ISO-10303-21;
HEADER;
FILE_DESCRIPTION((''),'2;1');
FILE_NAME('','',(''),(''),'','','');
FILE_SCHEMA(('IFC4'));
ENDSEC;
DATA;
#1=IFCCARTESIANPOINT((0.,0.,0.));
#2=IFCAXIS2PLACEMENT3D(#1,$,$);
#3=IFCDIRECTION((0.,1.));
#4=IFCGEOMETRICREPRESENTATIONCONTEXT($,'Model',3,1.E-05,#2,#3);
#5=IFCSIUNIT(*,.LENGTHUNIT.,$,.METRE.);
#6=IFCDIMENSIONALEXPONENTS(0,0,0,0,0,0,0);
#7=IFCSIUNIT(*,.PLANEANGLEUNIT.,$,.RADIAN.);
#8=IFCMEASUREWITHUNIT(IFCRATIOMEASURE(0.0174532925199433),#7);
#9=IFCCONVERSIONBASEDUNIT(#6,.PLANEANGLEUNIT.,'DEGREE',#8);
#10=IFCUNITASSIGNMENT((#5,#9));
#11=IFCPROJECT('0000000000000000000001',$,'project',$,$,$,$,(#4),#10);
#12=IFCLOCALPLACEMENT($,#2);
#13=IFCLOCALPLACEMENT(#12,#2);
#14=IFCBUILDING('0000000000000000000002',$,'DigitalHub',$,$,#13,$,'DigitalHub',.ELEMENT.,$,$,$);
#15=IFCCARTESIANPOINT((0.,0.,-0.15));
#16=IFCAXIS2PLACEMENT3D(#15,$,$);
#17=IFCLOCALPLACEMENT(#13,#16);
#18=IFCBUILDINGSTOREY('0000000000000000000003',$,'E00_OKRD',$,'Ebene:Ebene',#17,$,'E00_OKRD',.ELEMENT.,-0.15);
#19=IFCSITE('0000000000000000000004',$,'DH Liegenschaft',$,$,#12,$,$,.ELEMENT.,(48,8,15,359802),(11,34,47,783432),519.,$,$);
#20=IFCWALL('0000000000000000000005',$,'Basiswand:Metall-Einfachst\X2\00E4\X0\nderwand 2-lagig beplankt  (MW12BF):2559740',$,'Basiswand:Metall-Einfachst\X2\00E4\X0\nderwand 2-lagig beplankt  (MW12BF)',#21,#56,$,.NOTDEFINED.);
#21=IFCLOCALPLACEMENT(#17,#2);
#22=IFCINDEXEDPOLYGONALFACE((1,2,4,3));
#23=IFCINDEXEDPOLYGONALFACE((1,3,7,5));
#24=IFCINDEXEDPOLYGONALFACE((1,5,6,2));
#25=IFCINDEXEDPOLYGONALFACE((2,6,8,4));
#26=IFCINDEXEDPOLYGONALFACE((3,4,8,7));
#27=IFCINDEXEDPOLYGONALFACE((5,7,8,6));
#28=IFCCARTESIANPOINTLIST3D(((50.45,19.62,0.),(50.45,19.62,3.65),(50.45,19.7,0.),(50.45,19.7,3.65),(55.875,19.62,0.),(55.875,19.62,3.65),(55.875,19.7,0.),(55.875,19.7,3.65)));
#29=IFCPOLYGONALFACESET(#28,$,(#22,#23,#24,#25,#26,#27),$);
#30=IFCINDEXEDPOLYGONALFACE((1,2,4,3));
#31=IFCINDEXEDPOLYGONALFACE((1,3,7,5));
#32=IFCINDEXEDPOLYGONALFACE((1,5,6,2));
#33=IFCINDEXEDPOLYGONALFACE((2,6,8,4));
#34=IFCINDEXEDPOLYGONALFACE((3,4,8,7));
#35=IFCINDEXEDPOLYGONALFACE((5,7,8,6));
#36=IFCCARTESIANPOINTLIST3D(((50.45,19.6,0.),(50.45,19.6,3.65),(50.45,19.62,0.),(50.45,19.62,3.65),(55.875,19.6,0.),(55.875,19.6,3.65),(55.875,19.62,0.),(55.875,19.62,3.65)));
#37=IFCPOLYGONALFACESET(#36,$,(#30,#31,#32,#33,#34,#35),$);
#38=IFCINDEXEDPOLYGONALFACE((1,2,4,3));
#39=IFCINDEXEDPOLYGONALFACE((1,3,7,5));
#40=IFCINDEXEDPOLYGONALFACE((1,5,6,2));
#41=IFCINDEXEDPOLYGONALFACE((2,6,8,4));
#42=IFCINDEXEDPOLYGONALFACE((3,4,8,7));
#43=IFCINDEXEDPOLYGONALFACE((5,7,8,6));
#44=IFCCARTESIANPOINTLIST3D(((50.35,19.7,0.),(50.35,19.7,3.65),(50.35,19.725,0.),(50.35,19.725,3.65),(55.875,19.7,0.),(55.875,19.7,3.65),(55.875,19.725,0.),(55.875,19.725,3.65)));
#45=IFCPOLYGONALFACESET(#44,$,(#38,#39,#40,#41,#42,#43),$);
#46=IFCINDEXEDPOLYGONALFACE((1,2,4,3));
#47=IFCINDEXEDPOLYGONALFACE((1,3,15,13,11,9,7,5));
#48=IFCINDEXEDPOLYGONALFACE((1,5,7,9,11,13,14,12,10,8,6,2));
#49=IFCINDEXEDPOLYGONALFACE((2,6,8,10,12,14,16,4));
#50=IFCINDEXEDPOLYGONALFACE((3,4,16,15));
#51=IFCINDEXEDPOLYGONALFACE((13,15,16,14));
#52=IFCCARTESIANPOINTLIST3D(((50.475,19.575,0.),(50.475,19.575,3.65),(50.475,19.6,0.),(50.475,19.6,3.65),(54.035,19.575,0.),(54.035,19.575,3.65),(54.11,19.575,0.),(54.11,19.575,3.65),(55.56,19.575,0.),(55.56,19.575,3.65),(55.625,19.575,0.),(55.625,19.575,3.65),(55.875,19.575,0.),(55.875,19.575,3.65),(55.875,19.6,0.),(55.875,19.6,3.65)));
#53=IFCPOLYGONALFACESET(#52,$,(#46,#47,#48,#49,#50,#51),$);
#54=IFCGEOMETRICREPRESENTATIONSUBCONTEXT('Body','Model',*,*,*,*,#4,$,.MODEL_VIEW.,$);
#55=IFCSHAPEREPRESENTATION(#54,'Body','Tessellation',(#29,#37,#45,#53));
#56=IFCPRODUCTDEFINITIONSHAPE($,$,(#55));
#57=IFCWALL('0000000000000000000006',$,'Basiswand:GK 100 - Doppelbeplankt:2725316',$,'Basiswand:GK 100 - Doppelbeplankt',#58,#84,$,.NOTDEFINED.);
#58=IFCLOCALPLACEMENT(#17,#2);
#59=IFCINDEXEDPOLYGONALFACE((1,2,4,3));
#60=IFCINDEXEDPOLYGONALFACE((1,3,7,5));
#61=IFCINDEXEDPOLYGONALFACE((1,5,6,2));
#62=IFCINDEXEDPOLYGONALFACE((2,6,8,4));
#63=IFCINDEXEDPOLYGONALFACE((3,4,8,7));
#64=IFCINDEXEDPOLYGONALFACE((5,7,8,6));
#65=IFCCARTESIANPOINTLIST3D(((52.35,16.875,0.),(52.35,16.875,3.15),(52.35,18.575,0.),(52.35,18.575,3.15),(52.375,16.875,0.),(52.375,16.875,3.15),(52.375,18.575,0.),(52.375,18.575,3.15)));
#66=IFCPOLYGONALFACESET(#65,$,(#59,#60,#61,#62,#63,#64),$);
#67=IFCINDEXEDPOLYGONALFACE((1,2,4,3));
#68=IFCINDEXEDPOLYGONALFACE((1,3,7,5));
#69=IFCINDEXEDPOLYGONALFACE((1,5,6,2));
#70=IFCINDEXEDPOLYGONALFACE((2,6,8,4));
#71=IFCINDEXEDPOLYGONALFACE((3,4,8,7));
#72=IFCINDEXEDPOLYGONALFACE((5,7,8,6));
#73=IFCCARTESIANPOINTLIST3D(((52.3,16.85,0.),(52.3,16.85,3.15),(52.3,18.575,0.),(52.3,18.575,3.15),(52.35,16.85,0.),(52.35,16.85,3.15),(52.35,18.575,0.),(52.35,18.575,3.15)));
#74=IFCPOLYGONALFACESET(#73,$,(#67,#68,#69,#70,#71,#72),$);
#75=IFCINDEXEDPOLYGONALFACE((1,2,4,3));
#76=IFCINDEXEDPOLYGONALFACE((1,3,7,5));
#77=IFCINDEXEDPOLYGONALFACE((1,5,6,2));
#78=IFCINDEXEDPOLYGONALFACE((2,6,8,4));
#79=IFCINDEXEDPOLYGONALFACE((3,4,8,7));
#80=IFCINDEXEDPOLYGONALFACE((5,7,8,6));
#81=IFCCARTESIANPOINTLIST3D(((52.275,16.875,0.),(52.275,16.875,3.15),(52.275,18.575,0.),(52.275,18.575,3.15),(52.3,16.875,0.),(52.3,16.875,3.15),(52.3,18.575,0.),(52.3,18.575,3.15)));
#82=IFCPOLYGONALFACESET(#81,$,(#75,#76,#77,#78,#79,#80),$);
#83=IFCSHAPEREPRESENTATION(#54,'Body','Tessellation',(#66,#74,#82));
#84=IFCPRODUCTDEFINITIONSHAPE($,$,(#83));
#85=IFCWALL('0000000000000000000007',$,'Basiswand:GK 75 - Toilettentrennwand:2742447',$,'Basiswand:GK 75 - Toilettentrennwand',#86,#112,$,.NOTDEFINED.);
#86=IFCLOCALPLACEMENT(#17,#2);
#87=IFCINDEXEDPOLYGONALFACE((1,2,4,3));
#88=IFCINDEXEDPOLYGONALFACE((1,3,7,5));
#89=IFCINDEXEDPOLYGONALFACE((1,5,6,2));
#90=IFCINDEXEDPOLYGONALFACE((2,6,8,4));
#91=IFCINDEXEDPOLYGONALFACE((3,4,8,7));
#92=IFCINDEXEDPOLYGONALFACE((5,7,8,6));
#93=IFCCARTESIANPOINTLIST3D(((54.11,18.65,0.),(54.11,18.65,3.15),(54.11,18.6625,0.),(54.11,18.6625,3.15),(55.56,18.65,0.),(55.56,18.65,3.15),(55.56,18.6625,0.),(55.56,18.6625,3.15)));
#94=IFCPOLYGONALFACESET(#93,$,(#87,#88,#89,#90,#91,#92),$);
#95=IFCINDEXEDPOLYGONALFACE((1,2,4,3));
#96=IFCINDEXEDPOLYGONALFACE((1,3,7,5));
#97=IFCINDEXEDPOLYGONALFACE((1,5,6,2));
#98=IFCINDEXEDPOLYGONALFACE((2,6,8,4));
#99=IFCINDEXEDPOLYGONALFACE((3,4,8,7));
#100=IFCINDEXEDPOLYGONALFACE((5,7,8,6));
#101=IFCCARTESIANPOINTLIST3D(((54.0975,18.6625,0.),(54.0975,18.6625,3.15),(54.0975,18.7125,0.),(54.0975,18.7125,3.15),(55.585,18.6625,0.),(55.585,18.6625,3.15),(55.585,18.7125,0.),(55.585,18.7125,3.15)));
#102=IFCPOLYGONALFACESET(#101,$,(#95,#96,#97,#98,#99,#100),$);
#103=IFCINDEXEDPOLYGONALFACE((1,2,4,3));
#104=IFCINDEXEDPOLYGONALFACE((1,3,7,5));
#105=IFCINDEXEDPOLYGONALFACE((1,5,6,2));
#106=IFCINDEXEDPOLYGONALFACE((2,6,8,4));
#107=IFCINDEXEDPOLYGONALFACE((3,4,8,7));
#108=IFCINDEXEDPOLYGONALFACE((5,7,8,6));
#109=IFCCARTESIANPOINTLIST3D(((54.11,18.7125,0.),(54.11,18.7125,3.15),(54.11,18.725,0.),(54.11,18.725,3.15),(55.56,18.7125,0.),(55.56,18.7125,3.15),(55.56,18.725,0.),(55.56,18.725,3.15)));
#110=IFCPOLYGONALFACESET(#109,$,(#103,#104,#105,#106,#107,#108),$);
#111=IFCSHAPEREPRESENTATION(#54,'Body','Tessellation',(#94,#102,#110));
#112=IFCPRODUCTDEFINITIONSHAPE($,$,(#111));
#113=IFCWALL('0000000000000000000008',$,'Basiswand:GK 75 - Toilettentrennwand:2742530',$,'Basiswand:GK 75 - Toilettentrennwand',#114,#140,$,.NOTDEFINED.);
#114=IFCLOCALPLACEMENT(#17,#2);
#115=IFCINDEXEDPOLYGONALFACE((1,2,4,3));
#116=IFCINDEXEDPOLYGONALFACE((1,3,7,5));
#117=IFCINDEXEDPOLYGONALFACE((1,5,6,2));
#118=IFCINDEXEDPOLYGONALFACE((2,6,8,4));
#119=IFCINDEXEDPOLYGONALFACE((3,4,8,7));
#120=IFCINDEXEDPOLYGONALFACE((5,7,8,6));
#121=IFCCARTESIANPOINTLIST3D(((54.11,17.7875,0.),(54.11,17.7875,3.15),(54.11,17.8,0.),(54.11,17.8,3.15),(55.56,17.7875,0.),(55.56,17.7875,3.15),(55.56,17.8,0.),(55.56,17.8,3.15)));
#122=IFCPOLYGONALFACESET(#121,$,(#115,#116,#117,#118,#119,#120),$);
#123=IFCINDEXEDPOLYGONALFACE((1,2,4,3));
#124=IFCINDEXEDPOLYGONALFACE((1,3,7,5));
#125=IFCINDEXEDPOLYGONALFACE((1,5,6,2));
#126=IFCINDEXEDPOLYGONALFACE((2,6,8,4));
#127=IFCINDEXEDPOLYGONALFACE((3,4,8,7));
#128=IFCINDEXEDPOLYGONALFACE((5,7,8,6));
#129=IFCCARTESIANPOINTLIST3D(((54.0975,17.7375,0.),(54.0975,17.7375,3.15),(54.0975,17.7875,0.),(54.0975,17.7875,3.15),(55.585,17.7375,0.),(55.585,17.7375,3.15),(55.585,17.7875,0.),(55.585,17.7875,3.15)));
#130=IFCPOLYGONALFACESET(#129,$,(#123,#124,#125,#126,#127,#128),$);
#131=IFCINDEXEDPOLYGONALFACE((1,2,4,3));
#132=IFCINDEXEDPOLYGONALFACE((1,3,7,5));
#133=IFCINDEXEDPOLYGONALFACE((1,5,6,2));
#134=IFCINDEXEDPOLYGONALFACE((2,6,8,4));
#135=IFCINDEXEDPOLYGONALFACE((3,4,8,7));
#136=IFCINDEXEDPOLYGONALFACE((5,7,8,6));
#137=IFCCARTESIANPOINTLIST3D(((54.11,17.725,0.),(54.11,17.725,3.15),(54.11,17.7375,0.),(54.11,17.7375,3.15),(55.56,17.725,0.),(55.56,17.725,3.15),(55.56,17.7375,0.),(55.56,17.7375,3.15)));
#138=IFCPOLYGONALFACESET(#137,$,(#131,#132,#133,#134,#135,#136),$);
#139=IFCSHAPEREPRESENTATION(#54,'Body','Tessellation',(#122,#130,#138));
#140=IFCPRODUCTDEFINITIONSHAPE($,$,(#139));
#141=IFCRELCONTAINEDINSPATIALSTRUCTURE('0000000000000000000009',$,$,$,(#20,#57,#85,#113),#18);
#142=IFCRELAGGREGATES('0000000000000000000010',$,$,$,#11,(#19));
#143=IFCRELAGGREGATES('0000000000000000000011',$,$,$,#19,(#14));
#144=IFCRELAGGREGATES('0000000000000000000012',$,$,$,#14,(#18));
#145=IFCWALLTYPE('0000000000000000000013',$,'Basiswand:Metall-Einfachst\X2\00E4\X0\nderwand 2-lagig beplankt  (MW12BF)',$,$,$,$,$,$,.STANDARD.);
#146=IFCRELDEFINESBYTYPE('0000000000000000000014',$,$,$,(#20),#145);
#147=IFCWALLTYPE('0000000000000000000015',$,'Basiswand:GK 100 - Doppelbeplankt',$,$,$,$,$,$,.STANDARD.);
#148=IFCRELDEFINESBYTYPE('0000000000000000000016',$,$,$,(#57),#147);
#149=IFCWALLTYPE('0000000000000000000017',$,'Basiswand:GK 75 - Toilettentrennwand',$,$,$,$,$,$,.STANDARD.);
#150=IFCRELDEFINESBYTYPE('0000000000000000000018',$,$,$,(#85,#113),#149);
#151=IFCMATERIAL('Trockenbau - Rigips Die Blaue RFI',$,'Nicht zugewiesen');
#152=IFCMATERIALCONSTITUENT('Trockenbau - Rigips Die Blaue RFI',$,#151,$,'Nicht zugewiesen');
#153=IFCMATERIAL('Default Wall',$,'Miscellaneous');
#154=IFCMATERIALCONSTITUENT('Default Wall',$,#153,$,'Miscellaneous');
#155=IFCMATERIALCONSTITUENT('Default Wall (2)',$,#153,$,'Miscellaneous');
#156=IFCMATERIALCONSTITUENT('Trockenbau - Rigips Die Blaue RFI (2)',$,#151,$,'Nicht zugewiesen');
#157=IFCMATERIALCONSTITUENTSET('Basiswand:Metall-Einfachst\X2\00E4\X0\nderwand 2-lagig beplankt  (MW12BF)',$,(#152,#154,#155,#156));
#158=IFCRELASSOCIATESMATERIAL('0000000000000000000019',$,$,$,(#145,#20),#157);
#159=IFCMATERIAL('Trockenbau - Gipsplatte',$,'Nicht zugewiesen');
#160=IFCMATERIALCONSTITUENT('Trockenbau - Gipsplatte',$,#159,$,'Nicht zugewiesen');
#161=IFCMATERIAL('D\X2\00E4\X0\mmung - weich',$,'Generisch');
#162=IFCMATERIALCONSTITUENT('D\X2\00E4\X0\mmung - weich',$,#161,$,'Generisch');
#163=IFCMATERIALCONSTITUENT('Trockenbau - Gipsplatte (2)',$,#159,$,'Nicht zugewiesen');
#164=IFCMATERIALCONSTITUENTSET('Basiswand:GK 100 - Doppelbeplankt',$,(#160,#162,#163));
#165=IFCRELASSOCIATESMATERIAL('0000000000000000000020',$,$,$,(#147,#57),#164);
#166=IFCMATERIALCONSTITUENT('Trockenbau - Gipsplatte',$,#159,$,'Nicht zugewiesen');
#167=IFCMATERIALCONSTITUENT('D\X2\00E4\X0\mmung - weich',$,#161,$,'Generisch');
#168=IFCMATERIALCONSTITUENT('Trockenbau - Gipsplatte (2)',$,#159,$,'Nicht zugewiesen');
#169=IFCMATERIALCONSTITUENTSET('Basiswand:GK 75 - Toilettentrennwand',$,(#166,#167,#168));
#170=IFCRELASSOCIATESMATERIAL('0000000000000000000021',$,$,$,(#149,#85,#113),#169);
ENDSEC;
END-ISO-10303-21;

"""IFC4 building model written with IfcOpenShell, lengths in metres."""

from ifc_helpers import new_model, entity, si_unit, converted_unit, direction, frame, origin, place, context, subcontext, project, spatial, indexed_curve, outline, extrude, material, constituent, constituent_set, type_object, element, save


model = new_model("IFC4")

# Units and contexts
model_context = context("Model", 3, precision=1e-05, world=origin(), true_north=direction((0.0, 1.0)))
body_context = subcontext(model_context, "Body", "Model", "MODEL_VIEW")
ifc_project = project(units=[si_unit("LENGTHUNIT", "METRE"), converted_unit("PLANEANGLEUNIT", "DEGREE", entity("IfcRatioMeasure", 0.0174532925199433), si_unit("PLANEANGLEUNIT", "RADIAN"), dimensions=[0, 0, 0, 0, 0, 0, 0])], contexts=[model_context])

# Site, building, storey
site_placement = place(None, frame((0.0, 0.0, 0.0)))
site = spatial("IfcSite", under=ifc_project, at=site_placement, Name="DH Liegenschaft", CompositionType="ELEMENT", RefLatitude=(48, 8, 15, 359802), RefLongitude=(11, 34, 47, 783432), RefElevation=519.0)
building_placement = place(site_placement, origin())
building = spatial("IfcBuilding", under=site, at=building_placement, Name="DigitalHub", LongName="DigitalHub", CompositionType="ELEMENT")
storey_placement = place(building_placement, frame((0.0, 0.0, -0.15)))
storey = spatial("IfcBuildingStorey", under=building, at=storey_placement, Name="E00_OKRD", ObjectType="Ebene:Ebene", LongName="E00_OKRD", CompositionType="ELEMENT", Elevation=-0.15)

# Shared definitions
ifc_material_1 = material(Name="Trockenbau - Rigips Die Blaue RFI", Category="Nicht zugewiesen")
ifc_constituent_1 = constituent(ifc_material_1, Name="Trockenbau - Rigips Die Blaue RFI", Category="Nicht zugewiesen")
ifc_material_2 = material(Name="Default Wall", Category="Miscellaneous")
ifc_constituent_2 = constituent(ifc_material_2, Name="Default Wall", Category="Miscellaneous")
ifc_constituent_3 = constituent(ifc_material_2, Name="Default Wall (2)", Category="Miscellaneous")
ifc_constituent_4 = constituent(ifc_material_1, Name="Trockenbau - Rigips Die Blaue RFI (2)", Category="Nicht zugewiesen")
ifc_constituent_set_1 = constituent_set(constituents=[ifc_constituent_1, ifc_constituent_2, ifc_constituent_3, ifc_constituent_4], Name="Basiswand:Metall-Einfachständerwand 2-lagig beplankt  (MW12BF)")
wall_type_1 = type_object("IfcWallType", Name="Basiswand:Metall-Einfachständerwand 2-lagig beplankt  (MW12BF)", PredefinedType="STANDARD", material=ifc_constituent_set_1)

# Walls
wall_1_placement = place(storey_placement, frame((55.875, 19.65, 0.0), z_axis=(0.0, 0.0, 1.0), x_axis=(-1.0, 0.0, 0.0)))
element("IfcWall", 1, at=wall_1_placement, inside=storey, type_object=wall_type_1, material=ifc_constituent_set_1, Name="Basiswand:Metall-Einfachständerwand 2-lagig beplankt  (MW12BF):2559740", ObjectType="Basiswand:Metall-Einfachständerwand 2-lagig beplankt  (MW12BF)", PredefinedType="NOTDEFINED", context=body_context, shape_type="SweptSolid", body=[
    extrude(outline(indexed_curve([(-2.7125, -0.04), (2.7125, -0.04), (2.7125, 0.04), (-2.7125, 0.04), (-2.7125, -0.04)], self_intersect=False)), frame((2.7125, -0.01, 0.0)), (0.0, 0.0, 1.0), 3.65),
    extrude(outline(indexed_curve([(-2.7125, -0.01), (2.7125, -0.01), (2.7125, 0.01), (-2.7125, 0.01), (-2.7125, -0.01)], self_intersect=False)), frame((2.7125, 0.04, 0.0)), (0.0, 0.0, 1.0), 3.65),
    extrude(outline(indexed_curve([(-0.0125, -2.7625), (0.0125, -2.7625), (0.0125, 2.7625), (-0.0125, 2.7625), (-0.0125, -2.7625)], self_intersect=False)), frame((2.7625, -0.0625, 0.0), z_axis=(0.0, 0.0, 1.0), x_axis=(0.0, 1.0, 0.0)), (0.0, 0.0, 1.0), 3.65),
    extrude(outline(indexed_curve([(0.0313, -0.0063), (0.1063, -0.0063), (1.5563, -0.0063), (1.6213, -0.0063), (1.8712, -0.0063), (1.8712, 0.0187), (-3.5288, 0.0188), (-3.5288, -0.0062), (0.0313, -0.0063)], self_intersect=False)), frame((1.8713, 0.0687, 0.0), z_axis=(0.0, 0.0, 1.0), x_axis=(-1.0, 0.0, 0.0)), (0.0, 0.0, 1.0), 3.65),
])
ifc_material_3 = material(Name="Trockenbau - Gipsplatte", Category="Nicht zugewiesen")
ifc_material_4 = material(Name="Dämmung - weich", Category="Generisch")
ifc_constituent_5 = constituent(ifc_material_3, Name="Trockenbau - Gipsplatte", Category="Nicht zugewiesen")
ifc_constituent_6 = constituent(ifc_material_4, Name="Dämmung - weich", Category="Generisch")
ifc_constituent_7 = constituent(ifc_material_3, Name="Trockenbau - Gipsplatte (2)", Category="Nicht zugewiesen")
ifc_constituent_set_2 = constituent_set(constituents=[ifc_constituent_5, ifc_constituent_6, ifc_constituent_7], Name="Basiswand:GK 100 - Doppelbeplankt")
wall_type_2 = type_object("IfcWallType", Name="Basiswand:GK 100 - Doppelbeplankt", PredefinedType="STANDARD", material=ifc_constituent_set_2)
wall_2_placement = place(storey_placement, frame((52.325, 16.875, 0.0), z_axis=(0.0, 0.0, 1.0), x_axis=(0.0, 1.0, 0.0)))
element("IfcWall", 2, at=wall_2_placement, inside=storey, type_object=wall_type_2, material=ifc_constituent_set_2, Name="Basiswand:GK 100 - Doppelbeplankt:2725316", ObjectType="Basiswand:GK 100 - Doppelbeplankt", PredefinedType="NOTDEFINED", context=body_context, shape_type="SweptSolid", body=[
    extrude(outline(indexed_curve([(-0.0125, -0.85), (0.0125, -0.85), (0.0125, 0.85), (-0.0125, 0.85), (-0.0125, -0.85)], self_intersect=False)), frame((0.85, -0.0375, 0.0), z_axis=(0.0, 0.0, 1.0), x_axis=(0.0, 1.0, 0.0)), (0.0, 0.0, 1.0), 3.15),
    extrude(outline(indexed_curve([(-0.8625, -0.025), (0.8625, -0.025), (0.8625, 0.025), (-0.8625, 0.025), (-0.8625, -0.025)], self_intersect=False)), frame((0.8375, 0.0, 0.0)), (0.0, 0.0, 1.0), 3.15),
    extrude(outline(indexed_curve([(-0.0125, -0.85), (0.0125, -0.85), (0.0125, 0.85), (-0.0125, 0.85), (-0.0125, -0.85)], self_intersect=False)), frame((0.85, 0.0375, 0.0), z_axis=(0.0, 0.0, 1.0), x_axis=(0.0, -1.0, 0.0)), (0.0, 0.0, 1.0), 3.15),
])
ifc_constituent_8 = constituent(ifc_material_3, Name="Trockenbau - Gipsplatte", Category="Nicht zugewiesen")
ifc_constituent_9 = constituent(ifc_material_4, Name="Dämmung - weich", Category="Generisch")
ifc_constituent_10 = constituent(ifc_material_3, Name="Trockenbau - Gipsplatte (2)", Category="Nicht zugewiesen")
ifc_constituent_set_3 = constituent_set(constituents=[ifc_constituent_8, ifc_constituent_9, ifc_constituent_10], Name="Basiswand:GK 75 - Toilettentrennwand")
wall_type_3 = type_object("IfcWallType", Name="Basiswand:GK 75 - Toilettentrennwand", PredefinedType="STANDARD", material=ifc_constituent_set_3)
wall_3_placement = place(storey_placement, frame((55.56, 18.6875, 0.0), z_axis=(0.0, 0.0, 1.0), x_axis=(-1.0, 0.0, 0.0)))
element("IfcWall", 3, at=wall_3_placement, inside=storey, type_object=wall_type_3, material=ifc_constituent_set_3, Name="Basiswand:GK 75 - Toilettentrennwand:2742447", ObjectType="Basiswand:GK 75 - Toilettentrennwand", PredefinedType="NOTDEFINED", context=body_context, shape_type="SweptSolid", body=[
    extrude(outline(indexed_curve([(-0.0062, -0.725), (0.0063, -0.725), (0.0063, 0.725), (-0.0062, 0.725), (-0.0062, -0.725)], self_intersect=False)), frame((0.725, 0.0313, 0.0), z_axis=(0.0, 0.0, 1.0), x_axis=(0.0, -1.0, 0.0)), (0.0, 0.0, 1.0), 3.15),
    extrude(outline(indexed_curve([(-0.7437, -0.025), (0.7437, -0.025), (0.7437, 0.025), (-0.7437, 0.025), (-0.7437, -0.025)], self_intersect=False)), frame((0.7187, 0.0, 0.0)), (0.0, 0.0, 1.0), 3.15),
    extrude(outline(indexed_curve([(-0.0062, -0.725), (0.0063, -0.725), (0.0063, 0.725), (-0.0062, 0.725), (-0.0062, -0.725)], self_intersect=False)), frame((0.725, -0.0313, 0.0), z_axis=(0.0, 0.0, 1.0), x_axis=(0.0, 1.0, 0.0)), (0.0, 0.0, 1.0), 3.15),
])
wall_4_placement = place(storey_placement, frame((55.56, 17.7625, 0.0), z_axis=(0.0, 0.0, 1.0), x_axis=(-1.0, 0.0, 0.0)))
element("IfcWall", 4, at=wall_4_placement, inside=storey, type_object=wall_type_3, material=ifc_constituent_set_3, Name="Basiswand:GK 75 - Toilettentrennwand:2742530", ObjectType="Basiswand:GK 75 - Toilettentrennwand", PredefinedType="NOTDEFINED", context=body_context, shape_type="SweptSolid", body=[
    extrude(outline(indexed_curve([(-0.0063, -0.725), (0.0062, -0.725), (0.0063, 0.725), (-0.0062, 0.725), (-0.0063, -0.725)], self_intersect=False)), frame((0.725, -0.0313, 0.0), z_axis=(0.0, 0.0, 1.0), x_axis=(0.0, 1.0, 0.0)), (0.0, 0.0, 1.0), 3.15),
    extrude(outline(indexed_curve([(-0.7437, -0.025), (0.7437, -0.025), (0.7437, 0.025), (-0.7437, 0.025), (-0.7437, -0.025)], self_intersect=False)), frame((0.7187, 0.0, 0.0)), (0.0, 0.0, 1.0), 3.15),
    extrude(outline(indexed_curve([(-0.0063, -0.725), (0.0062, -0.725), (0.0063, 0.725), (-0.0062, 0.725), (-0.0063, -0.725)], self_intersect=False)), frame((0.725, 0.0312, 0.0), z_axis=(0.0, 0.0, 1.0), x_axis=(0.0, -1.0, 0.0)), (0.0, 0.0, 1.0), 3.15),
])

save(model, "model.ifc")
